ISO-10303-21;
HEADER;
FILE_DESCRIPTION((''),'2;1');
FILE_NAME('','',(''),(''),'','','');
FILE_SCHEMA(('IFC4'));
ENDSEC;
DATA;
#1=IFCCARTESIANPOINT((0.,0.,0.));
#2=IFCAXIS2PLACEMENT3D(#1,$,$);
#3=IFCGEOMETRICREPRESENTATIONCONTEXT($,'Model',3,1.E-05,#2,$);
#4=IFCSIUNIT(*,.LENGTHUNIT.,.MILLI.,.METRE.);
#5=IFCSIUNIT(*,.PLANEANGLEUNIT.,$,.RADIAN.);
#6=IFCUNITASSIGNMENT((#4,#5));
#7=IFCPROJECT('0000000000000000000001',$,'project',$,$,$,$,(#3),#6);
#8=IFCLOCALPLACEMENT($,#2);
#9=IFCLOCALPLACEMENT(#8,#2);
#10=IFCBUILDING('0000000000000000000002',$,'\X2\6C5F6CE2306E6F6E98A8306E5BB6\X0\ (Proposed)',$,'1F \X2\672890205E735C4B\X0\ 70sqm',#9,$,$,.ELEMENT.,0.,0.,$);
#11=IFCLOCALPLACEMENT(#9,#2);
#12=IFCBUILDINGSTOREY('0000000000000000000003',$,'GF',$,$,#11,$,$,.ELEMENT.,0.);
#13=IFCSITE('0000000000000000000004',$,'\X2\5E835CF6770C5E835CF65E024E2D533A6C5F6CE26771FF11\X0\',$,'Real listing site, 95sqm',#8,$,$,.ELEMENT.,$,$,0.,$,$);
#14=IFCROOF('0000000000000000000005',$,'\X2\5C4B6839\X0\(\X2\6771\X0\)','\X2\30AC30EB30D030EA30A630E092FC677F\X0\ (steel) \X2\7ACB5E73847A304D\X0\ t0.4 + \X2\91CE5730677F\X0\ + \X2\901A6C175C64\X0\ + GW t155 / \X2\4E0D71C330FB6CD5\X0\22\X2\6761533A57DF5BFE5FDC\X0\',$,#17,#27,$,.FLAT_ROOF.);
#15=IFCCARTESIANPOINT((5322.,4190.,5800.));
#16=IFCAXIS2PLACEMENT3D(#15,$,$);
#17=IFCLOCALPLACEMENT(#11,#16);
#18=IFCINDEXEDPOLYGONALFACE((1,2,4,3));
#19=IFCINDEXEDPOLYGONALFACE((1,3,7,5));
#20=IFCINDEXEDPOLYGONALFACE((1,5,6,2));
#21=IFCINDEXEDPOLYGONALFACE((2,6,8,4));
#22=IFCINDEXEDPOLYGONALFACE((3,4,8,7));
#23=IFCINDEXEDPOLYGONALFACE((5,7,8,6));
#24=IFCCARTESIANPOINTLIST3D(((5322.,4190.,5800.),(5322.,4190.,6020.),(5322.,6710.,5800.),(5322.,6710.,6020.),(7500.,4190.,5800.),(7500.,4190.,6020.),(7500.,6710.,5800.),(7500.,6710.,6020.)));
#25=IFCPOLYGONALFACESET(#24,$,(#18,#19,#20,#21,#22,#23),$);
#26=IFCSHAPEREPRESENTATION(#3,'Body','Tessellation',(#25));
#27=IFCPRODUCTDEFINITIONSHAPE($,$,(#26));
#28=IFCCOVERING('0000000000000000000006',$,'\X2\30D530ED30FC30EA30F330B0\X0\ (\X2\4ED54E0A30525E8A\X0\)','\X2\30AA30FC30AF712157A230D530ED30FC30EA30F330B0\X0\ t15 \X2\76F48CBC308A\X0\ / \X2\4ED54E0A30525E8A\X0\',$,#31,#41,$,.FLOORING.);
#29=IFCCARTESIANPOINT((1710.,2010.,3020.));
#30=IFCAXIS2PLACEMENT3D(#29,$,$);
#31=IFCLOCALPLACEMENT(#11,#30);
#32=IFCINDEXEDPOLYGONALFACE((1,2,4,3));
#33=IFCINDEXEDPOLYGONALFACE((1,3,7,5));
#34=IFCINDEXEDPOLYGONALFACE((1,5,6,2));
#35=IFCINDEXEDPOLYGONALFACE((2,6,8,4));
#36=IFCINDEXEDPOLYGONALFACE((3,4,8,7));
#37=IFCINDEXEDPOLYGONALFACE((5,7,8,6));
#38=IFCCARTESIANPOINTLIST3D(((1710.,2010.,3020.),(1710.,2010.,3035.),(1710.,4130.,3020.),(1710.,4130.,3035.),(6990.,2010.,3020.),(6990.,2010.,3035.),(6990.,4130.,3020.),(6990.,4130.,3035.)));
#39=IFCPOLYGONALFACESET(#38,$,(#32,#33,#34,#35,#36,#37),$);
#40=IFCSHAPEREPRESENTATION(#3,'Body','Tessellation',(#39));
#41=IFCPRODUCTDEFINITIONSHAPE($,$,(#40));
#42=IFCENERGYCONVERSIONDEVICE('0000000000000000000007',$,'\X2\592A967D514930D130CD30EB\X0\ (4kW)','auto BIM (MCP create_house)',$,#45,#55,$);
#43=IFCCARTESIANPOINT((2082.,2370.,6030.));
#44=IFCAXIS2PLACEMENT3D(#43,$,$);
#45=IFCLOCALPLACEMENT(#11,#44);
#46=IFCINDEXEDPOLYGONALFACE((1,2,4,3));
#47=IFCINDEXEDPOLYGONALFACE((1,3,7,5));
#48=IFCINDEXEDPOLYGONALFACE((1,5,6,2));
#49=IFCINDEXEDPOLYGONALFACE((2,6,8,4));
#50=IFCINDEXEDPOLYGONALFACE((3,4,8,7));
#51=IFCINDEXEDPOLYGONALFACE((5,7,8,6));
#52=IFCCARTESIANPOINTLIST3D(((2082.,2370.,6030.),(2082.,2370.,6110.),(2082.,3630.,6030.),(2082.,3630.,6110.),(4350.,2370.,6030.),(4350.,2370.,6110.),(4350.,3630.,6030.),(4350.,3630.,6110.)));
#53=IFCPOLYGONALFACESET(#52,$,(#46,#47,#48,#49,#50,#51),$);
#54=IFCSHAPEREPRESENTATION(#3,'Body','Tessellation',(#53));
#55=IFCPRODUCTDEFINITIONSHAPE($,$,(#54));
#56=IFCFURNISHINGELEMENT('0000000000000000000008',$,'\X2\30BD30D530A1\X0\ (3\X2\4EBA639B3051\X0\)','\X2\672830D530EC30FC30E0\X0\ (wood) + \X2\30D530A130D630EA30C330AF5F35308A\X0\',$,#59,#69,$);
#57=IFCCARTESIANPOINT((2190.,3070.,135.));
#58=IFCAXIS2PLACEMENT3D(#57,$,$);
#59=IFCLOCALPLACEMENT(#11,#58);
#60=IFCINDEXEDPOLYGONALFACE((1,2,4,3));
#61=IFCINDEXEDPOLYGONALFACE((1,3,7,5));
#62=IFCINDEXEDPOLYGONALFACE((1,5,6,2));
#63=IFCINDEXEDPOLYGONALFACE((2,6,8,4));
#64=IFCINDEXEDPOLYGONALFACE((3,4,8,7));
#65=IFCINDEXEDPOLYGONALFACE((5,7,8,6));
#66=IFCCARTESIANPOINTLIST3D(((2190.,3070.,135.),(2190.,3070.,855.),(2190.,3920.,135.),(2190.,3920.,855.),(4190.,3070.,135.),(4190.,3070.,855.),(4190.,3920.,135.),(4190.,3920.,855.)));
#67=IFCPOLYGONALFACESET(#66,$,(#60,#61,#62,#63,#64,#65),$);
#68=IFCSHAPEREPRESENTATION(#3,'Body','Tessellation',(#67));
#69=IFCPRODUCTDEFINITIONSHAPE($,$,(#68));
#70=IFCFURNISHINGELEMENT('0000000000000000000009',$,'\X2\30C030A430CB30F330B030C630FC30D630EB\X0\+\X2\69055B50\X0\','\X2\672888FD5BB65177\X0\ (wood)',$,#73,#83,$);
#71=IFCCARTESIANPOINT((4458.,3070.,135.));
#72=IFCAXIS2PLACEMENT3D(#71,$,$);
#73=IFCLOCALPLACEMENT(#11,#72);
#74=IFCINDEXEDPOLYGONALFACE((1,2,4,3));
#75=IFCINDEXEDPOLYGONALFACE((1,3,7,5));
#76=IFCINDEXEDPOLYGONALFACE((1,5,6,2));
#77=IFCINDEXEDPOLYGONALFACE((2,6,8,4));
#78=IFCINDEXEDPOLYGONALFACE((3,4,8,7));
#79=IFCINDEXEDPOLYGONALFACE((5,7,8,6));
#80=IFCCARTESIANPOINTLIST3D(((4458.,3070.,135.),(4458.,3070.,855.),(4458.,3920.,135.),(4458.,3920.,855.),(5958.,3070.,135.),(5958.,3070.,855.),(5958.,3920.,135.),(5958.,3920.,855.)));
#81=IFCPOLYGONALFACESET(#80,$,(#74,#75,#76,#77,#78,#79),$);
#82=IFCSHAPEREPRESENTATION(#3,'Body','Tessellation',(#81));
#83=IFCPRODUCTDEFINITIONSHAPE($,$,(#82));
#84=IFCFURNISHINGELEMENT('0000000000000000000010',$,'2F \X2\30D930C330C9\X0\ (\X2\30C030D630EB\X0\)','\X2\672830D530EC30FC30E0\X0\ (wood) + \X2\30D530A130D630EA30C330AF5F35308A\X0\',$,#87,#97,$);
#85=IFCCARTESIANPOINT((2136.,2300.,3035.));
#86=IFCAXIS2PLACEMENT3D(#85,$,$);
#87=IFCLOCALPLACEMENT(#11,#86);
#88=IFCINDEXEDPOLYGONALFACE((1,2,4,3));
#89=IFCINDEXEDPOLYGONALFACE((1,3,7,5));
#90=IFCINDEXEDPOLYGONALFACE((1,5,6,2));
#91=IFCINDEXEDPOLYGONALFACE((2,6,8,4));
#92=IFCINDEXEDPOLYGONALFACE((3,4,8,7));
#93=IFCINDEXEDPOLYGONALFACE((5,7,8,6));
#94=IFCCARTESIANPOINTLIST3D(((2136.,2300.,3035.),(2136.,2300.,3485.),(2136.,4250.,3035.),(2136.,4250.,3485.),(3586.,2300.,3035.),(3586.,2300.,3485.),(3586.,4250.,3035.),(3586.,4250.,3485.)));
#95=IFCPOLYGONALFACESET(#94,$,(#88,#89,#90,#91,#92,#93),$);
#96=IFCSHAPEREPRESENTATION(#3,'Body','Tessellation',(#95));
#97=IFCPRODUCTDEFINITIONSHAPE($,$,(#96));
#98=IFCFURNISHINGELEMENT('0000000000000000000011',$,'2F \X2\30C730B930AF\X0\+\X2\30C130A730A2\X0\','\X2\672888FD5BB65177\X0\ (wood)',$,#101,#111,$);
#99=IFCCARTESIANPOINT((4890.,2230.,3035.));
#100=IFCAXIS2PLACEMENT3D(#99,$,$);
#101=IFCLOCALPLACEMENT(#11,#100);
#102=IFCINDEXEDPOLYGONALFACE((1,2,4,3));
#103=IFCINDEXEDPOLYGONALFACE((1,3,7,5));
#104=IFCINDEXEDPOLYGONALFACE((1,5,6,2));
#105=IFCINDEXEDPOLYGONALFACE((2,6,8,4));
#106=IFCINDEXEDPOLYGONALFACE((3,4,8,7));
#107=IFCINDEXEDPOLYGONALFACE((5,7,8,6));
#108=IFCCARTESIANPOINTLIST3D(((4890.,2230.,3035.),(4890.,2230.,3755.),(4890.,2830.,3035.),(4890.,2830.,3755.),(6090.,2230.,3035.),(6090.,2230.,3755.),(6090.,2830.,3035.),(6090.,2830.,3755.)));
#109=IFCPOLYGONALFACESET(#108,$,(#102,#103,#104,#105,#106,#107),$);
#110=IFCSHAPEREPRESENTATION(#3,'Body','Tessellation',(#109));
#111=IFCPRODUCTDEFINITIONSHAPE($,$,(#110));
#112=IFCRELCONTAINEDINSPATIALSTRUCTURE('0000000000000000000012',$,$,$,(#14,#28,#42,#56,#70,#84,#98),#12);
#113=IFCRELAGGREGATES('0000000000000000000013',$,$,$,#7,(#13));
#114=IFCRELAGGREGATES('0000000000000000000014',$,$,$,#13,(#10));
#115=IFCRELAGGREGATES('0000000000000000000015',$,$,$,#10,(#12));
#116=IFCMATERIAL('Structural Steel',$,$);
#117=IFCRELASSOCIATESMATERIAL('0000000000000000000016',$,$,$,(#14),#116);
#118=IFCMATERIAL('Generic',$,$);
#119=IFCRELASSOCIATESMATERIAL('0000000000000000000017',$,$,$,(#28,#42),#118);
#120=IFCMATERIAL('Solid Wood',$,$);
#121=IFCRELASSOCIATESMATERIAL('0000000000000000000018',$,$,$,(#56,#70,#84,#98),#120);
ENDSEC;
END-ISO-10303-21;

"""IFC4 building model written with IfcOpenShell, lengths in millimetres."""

from ifc_helpers import new_model, si_unit, frame, frame_2d, origin, place, context, project, spatial, rectangle, extrude, material, element, save


model = new_model("IFC4")

# Units and contexts
model_context = context("Model", 3, precision=1e-05, world=origin())
ifc_project = project(units=[si_unit("LENGTHUNIT", "METRE", prefix="MILLI"), si_unit("PLANEANGLEUNIT", "RADIAN")], contexts=[model_context])

# Site, building, storey
site_placement = place(None, origin())
site = spatial("IfcSite", under=ifc_project, at=site_placement, Name="広島県広島市中区江波東１", ObjectType="Real listing site, 95sqm", CompositionType="ELEMENT", RefElevation=0.0)
building_placement = place(site_placement, origin())
building = spatial("IfcBuilding", under=site, at=building_placement, Name="江波の潮風の家 (Proposed)", ObjectType="1F 木造平屋 70sqm", CompositionType="ELEMENT", ElevationOfRefHeight=0.0, ElevationOfTerrain=0.0)
storey_placement = place(building_placement, origin())
storey = spatial("IfcBuildingStorey", under=building, at=storey_placement, Name="GF", CompositionType="ELEMENT", Elevation=0.0)

# Shared definitions
ifc_material_1 = material(Name="Solid Wood")

# Roof
ifc_material_2 = material(Name="Structural Steel")
roof_1_placement = place(storey_placement, frame((5322.0, 4190.0, 5800.0)))
element("IfcRoof", 1, at=roof_1_placement, inside=storey, material=ifc_material_2, Name="屋根(東)", Description="ガルバリウム鋼板 (steel) 立平葺き t0.4 + 野地板 + 通気層 + GW t155 / 不燃・法22条区域対応", PredefinedType="FLAT_ROOF", context=model_context, shape_type="SweptSolid", body=[
    extrude(rectangle(XDim=2178.0, YDim=2520.0, at=frame_2d((1089.0, 1260.0))), frame((5322.0, 4190.0, 5800.0)), (0.0, 0.0, 1.0), 220.0),
])

# Covering
ifc_material_3 = material(Name="Generic")
covering_placement = place(storey_placement, frame((1710.0, 2010.0, 3020.0)))
element("IfcCovering", 2, at=covering_placement, inside=storey, material=ifc_material_3, Name="フローリング (仕上げ床)", Description="オーク無垢フローリング t15 直貼り / 仕上げ床", PredefinedType="FLOORING", context=model_context, shape_type="SweptSolid", body=[
    extrude(rectangle(XDim=5280.0, YDim=2120.0, at=frame_2d((2640.0, 1060.0))), frame((1710.0, 2010.0, 3020.0)), (0.0, 0.0, 1.0), 15.0),
])

# Energy conversion device
energy_conversion_device_placement = place(storey_placement, frame((2082.0, 2370.0, 6030.0)))
element("IfcEnergyConversionDevice", 3, at=energy_conversion_device_placement, inside=storey, material=ifc_material_3, Name="太陽光パネル (4kW)", Description="auto BIM (MCP create_house)", context=model_context, shape_type="SweptSolid", body=[
    extrude(rectangle(XDim=2268.0, YDim=1260.0, at=frame_2d((1134.0, 630.0))), frame((2082.0, 2370.0, 6030.0)), (0.0, 0.0, 1.0), 80.0),
])

# Furnishing elements
furnishing_1_placement = place(storey_placement, frame((2190.0, 3070.0, 135.0)))
element("IfcFurnishingElement", 4, at=furnishing_1_placement, inside=storey, material=ifc_material_1, Name="ソファ (3人掛け)", Description="木フレーム (wood) + ファブリック張り", context=model_context, shape_type="SweptSolid", body=[
    extrude(rectangle(XDim=2000.0, YDim=850.0, at=frame_2d((1000.0, 425.0))), frame((2190.0, 3070.0, 135.0)), (0.0, 0.0, 1.0), 720.0),
])
furnishing_2_placement = place(storey_placement, frame((4458.0, 3070.0, 135.0)))
element("IfcFurnishingElement", 5, at=furnishing_2_placement, inside=storey, material=ifc_material_1, Name="ダイニングテーブル+椅子", Description="木製家具 (wood)", context=model_context, shape_type="SweptSolid", body=[
    extrude(rectangle(XDim=1500.0, YDim=850.0, at=frame_2d((750.0, 425.0))), frame((4458.0, 3070.0, 135.0)), (0.0, 0.0, 1.0), 720.0),
])
furnishing_3_placement = place(storey_placement, frame((2136.0, 2300.0, 3035.0)))
element("IfcFurnishingElement", 6, at=furnishing_3_placement, inside=storey, material=ifc_material_1, Name="2F ベッド (ダブル)", Description="木フレーム (wood) + ファブリック張り", context=model_context, shape_type="SweptSolid", body=[
    extrude(rectangle(XDim=1450.0, YDim=1950.0, at=frame_2d((725.0, 975.0))), frame((2136.0, 2300.0, 3035.0)), (0.0, 0.0, 1.0), 450.0),
])
furnishing_4_placement = place(storey_placement, frame((4890.0, 2230.0, 3035.0)))
element("IfcFurnishingElement", 7, at=furnishing_4_placement, inside=storey, material=ifc_material_1, Name="2F デスク+チェア", Description="木製家具 (wood)", context=model_context, shape_type="SweptSolid", body=[
    extrude(rectangle(XDim=1200.0, YDim=600.0, at=frame_2d((600.0, 300.0))), frame((4890.0, 2230.0, 3035.0)), (0.0, 0.0, 1.0), 720.0),
])

save(model, "model.ifc")
